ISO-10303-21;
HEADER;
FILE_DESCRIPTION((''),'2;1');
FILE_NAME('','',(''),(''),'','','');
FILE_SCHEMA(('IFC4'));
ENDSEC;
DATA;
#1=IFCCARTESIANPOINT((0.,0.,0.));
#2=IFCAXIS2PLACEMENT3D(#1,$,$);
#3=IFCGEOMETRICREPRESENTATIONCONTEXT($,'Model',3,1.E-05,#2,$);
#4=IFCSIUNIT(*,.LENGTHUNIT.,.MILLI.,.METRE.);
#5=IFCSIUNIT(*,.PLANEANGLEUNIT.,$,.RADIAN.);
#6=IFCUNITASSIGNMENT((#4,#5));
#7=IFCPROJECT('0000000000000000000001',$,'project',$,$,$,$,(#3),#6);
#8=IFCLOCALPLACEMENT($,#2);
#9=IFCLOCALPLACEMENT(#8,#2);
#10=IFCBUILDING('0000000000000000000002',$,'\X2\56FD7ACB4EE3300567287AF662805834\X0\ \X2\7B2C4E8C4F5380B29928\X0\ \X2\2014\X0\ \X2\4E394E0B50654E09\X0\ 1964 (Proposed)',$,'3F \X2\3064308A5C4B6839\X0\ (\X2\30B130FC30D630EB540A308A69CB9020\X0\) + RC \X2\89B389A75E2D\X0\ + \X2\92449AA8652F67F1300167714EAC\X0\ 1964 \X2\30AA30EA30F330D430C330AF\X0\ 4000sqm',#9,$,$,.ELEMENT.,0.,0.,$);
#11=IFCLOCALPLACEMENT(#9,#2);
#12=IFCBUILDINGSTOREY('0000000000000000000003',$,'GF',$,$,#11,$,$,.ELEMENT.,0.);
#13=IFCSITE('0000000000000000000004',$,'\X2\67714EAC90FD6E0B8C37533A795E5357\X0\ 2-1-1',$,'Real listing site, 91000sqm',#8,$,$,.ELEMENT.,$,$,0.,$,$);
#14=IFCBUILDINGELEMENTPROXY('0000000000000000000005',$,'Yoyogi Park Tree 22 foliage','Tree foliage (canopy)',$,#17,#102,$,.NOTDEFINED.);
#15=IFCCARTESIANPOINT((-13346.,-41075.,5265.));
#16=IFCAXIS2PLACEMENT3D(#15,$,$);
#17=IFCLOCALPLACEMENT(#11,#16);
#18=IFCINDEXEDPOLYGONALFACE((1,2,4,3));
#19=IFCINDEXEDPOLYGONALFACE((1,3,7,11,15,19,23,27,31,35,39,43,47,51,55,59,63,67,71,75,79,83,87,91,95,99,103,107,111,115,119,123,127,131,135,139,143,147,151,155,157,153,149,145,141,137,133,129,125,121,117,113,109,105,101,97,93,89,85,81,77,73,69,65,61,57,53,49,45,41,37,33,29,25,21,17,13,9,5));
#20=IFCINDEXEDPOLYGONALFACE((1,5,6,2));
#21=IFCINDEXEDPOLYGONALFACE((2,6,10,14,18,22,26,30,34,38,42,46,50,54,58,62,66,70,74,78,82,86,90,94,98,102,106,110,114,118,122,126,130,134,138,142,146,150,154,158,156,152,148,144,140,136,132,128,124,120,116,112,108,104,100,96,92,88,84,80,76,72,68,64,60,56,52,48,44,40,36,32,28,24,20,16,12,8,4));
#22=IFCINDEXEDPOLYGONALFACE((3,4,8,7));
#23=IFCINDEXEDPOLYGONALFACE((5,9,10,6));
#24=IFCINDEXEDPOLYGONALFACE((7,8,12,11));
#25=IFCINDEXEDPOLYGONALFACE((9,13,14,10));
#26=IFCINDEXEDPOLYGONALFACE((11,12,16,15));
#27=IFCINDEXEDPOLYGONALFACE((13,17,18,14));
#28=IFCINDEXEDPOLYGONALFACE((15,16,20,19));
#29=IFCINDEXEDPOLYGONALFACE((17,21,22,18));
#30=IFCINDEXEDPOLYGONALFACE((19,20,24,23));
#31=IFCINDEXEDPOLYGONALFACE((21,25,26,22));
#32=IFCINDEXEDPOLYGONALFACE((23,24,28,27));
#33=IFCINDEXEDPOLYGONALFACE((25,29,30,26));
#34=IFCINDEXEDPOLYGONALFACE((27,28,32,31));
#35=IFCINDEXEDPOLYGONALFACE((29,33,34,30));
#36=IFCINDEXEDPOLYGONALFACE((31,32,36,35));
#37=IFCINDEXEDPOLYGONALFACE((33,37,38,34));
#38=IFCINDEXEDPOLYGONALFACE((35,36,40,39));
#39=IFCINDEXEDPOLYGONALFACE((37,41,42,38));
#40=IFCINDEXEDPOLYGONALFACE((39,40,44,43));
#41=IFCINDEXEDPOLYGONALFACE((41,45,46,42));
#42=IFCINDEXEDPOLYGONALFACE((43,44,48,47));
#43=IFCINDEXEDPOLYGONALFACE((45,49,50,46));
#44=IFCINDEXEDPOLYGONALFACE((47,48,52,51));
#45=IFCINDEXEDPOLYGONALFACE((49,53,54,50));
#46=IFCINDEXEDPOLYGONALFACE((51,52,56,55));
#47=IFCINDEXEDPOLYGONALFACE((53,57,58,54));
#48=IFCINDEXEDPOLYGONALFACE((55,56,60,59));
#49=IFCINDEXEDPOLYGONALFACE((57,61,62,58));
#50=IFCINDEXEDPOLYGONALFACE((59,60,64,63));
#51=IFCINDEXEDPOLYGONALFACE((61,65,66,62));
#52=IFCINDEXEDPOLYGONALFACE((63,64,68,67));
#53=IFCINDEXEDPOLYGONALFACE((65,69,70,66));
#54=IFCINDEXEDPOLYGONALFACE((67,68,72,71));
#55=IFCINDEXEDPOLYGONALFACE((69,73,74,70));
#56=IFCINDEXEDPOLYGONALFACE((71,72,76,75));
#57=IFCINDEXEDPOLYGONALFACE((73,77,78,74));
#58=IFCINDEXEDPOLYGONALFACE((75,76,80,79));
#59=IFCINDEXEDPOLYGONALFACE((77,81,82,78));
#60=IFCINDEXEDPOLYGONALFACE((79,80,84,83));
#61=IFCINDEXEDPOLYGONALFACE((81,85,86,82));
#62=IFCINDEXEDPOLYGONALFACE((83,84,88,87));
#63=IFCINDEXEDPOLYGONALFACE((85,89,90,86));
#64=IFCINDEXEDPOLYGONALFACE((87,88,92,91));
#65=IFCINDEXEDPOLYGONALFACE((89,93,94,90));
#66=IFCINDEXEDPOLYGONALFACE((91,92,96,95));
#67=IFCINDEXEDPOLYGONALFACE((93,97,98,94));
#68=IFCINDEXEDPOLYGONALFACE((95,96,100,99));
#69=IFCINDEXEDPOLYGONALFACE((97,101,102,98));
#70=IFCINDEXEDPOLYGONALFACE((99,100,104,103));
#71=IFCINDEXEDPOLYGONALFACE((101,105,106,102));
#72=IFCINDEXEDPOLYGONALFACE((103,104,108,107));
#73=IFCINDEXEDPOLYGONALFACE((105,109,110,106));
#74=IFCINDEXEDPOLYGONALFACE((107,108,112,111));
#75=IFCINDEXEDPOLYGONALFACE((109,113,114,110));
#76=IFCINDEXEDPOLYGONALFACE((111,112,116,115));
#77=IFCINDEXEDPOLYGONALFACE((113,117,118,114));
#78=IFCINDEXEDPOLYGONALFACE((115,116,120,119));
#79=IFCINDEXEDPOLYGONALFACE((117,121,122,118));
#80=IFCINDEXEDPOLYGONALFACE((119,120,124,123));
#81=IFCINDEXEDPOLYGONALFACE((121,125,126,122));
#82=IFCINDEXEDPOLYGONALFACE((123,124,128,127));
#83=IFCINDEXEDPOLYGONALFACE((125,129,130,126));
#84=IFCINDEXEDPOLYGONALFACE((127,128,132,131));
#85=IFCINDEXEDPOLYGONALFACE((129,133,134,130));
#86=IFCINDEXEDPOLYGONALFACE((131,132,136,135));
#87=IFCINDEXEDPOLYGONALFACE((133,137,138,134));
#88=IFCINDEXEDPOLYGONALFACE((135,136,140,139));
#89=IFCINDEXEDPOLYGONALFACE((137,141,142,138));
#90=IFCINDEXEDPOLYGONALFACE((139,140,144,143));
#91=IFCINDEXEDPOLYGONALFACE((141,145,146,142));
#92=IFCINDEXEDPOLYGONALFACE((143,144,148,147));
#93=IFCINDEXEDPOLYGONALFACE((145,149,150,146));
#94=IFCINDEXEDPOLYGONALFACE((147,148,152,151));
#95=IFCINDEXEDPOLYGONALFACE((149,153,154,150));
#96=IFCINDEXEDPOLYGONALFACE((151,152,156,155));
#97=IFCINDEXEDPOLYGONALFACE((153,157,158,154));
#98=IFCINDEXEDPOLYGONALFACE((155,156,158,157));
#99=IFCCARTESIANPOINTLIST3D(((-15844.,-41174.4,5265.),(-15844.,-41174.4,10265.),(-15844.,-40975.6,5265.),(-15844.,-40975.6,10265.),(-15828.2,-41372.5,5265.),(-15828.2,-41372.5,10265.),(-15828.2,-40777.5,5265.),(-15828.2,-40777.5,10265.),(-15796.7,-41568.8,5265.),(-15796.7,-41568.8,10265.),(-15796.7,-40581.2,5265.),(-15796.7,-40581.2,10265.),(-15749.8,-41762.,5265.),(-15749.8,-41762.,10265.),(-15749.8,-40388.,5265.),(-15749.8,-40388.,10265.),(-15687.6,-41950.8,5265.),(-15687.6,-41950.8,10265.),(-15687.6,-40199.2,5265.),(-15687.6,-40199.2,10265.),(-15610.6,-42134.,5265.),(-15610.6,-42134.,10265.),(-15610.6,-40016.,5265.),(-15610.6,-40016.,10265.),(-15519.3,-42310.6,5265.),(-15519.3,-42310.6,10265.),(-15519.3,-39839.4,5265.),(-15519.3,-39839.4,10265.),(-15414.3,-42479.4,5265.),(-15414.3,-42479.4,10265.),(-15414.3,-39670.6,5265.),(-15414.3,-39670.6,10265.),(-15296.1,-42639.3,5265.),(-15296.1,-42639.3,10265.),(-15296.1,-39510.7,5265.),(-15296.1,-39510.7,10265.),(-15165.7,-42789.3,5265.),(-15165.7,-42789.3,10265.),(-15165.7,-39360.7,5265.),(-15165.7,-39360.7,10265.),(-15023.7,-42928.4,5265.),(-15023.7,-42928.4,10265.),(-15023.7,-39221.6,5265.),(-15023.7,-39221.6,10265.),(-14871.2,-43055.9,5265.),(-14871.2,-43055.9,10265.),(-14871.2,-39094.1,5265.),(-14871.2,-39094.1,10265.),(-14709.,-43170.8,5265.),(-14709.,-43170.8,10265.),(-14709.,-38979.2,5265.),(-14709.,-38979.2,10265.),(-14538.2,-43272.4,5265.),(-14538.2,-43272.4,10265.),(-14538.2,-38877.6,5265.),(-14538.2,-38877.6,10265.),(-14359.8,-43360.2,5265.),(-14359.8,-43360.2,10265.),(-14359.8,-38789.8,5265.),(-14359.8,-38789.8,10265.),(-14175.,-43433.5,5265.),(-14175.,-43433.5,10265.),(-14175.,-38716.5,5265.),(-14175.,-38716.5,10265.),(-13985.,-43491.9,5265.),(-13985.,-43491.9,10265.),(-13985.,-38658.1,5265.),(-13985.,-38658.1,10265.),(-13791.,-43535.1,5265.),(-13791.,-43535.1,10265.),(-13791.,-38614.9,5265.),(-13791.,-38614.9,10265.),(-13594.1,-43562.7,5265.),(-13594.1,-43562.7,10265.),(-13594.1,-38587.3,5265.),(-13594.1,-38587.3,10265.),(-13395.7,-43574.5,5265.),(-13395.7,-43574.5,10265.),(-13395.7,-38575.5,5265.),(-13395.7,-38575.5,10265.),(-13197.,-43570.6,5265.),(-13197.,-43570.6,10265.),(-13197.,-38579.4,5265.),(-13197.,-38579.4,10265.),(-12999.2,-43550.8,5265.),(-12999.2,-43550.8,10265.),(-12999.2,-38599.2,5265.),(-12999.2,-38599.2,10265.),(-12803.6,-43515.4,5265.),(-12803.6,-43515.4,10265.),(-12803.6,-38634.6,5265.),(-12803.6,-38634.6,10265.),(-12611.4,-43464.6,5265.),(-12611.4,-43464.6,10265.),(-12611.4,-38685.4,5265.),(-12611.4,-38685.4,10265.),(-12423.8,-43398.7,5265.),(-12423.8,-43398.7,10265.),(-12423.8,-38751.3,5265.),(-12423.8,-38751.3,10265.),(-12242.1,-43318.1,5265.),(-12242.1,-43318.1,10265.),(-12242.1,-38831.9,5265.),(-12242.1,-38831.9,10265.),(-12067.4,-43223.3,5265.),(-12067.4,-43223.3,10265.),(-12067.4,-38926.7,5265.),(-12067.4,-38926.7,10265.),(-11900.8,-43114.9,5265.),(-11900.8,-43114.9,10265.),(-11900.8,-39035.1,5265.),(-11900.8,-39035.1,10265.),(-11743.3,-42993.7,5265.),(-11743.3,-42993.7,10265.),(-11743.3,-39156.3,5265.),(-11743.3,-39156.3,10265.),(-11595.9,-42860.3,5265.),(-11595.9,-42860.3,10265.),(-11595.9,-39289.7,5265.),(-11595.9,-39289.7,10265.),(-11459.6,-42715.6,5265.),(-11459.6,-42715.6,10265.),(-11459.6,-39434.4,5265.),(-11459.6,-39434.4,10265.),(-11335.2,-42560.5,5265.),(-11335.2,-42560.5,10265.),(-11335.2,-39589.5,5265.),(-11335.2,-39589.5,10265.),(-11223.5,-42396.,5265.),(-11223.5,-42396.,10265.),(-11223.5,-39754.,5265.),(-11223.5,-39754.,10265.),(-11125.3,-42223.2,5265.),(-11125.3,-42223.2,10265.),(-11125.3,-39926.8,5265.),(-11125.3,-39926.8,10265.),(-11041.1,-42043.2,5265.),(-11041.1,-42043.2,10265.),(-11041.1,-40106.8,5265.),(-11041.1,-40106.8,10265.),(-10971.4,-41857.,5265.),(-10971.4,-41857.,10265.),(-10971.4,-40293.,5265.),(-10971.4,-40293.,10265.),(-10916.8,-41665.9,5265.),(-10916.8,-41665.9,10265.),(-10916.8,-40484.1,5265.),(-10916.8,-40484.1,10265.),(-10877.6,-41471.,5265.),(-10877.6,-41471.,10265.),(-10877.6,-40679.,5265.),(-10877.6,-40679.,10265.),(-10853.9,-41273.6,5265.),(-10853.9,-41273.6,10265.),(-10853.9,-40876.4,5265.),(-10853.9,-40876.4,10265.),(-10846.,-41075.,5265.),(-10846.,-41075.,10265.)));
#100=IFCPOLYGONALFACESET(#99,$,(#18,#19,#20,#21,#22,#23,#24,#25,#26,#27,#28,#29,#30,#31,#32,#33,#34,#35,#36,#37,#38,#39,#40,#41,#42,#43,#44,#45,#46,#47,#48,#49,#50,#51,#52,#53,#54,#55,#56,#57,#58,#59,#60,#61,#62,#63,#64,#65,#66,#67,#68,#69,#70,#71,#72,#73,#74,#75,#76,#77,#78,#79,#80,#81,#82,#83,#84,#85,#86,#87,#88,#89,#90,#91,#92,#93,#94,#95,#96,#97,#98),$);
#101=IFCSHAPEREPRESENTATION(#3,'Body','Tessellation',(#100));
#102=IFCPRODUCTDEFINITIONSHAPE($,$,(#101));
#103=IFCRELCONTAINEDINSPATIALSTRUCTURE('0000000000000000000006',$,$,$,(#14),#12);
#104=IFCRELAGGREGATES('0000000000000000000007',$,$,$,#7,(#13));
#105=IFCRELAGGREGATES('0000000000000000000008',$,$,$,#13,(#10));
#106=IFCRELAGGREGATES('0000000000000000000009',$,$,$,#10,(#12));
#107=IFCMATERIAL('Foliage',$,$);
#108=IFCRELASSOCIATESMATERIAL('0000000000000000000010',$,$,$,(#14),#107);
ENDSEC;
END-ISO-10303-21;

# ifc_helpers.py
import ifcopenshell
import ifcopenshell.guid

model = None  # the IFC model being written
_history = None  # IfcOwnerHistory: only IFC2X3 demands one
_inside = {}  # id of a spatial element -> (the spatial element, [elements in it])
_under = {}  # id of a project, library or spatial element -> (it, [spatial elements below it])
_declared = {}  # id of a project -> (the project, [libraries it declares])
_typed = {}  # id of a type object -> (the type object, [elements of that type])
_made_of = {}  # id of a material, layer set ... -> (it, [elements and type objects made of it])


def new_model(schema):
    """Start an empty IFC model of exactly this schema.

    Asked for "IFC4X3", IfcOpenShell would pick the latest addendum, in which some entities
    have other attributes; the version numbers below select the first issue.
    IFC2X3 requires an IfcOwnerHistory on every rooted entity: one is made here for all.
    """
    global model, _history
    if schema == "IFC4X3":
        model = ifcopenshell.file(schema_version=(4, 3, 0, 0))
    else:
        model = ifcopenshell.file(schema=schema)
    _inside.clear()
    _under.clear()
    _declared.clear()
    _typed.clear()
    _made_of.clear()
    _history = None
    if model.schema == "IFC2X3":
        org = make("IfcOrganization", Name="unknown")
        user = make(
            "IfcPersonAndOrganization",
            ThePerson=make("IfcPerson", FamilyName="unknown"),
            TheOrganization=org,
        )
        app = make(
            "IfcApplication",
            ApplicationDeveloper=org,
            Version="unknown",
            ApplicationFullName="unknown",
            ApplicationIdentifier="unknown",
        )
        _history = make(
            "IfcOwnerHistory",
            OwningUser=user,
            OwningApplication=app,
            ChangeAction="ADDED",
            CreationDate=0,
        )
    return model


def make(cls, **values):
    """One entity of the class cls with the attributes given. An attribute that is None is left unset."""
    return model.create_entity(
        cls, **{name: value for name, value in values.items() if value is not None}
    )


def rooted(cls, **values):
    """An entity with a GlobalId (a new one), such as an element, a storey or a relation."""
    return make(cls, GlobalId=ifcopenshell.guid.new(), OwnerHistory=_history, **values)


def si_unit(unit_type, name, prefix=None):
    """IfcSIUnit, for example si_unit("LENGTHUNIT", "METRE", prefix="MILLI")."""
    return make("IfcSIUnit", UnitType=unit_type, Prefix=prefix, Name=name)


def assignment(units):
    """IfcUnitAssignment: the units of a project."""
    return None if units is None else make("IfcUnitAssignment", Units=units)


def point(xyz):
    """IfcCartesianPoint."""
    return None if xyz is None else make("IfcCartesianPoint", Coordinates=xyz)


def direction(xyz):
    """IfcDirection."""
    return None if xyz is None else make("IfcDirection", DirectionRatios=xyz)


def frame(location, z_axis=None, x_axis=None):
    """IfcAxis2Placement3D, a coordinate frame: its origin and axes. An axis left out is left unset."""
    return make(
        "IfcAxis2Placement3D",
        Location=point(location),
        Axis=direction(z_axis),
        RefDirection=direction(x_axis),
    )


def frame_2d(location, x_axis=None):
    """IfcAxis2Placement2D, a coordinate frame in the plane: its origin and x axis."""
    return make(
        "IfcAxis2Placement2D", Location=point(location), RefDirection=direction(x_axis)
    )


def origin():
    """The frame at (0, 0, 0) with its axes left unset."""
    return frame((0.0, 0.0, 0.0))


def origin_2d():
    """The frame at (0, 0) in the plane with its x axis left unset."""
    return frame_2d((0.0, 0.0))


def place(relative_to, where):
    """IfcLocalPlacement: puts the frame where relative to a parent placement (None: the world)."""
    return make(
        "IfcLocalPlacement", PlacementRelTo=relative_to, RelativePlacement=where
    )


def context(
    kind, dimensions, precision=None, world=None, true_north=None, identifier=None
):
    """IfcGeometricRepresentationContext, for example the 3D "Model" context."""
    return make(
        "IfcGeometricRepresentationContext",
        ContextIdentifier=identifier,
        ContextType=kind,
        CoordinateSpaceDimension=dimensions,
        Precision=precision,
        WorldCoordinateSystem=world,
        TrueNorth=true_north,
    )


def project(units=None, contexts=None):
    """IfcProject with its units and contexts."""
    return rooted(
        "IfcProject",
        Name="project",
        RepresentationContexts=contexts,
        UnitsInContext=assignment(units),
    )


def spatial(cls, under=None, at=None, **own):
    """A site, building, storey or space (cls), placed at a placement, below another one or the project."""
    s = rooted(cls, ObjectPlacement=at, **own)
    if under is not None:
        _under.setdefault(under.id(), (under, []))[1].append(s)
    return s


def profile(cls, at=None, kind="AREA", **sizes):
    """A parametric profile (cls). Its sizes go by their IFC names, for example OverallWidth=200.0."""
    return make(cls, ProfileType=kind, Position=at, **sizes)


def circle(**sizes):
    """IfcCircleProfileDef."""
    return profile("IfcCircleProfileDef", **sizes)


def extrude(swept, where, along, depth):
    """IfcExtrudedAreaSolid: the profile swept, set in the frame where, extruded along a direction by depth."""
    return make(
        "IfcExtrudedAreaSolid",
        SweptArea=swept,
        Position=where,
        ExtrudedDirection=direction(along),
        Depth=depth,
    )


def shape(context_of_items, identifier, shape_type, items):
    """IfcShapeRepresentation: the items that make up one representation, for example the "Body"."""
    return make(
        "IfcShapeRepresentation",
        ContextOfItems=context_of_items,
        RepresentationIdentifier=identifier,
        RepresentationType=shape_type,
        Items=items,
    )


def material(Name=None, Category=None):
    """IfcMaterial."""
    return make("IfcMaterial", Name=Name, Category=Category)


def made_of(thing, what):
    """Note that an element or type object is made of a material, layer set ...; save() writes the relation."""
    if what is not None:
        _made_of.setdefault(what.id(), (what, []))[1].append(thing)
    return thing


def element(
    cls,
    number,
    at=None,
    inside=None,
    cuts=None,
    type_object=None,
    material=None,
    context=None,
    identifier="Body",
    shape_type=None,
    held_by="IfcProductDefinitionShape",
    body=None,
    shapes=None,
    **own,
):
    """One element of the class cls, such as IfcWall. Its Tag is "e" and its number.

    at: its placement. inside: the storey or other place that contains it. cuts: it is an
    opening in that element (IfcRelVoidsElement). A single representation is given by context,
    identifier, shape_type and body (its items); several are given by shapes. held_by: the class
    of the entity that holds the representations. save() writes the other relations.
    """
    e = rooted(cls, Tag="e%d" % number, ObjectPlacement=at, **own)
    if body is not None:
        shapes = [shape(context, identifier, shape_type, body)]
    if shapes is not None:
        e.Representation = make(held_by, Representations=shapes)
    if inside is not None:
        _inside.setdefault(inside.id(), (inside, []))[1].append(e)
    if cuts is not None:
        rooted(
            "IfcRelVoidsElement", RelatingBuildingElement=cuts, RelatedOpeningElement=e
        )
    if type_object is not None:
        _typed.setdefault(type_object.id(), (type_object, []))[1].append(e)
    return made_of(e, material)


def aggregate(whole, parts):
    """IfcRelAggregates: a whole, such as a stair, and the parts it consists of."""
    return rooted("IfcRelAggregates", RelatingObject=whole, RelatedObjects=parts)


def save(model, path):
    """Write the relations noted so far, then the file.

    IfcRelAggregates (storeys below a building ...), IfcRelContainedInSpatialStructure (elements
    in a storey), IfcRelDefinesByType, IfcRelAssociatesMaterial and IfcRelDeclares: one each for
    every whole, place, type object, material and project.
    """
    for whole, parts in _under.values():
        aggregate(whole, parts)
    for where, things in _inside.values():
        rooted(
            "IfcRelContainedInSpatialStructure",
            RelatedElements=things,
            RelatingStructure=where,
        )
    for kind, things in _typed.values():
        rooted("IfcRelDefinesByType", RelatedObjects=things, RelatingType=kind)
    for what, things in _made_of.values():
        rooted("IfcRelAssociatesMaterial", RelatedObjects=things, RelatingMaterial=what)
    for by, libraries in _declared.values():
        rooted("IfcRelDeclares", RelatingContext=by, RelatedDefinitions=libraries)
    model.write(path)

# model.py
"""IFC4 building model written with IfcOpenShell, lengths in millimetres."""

from ifc_helpers import new_model, si_unit, frame, origin, origin_2d, place, context, project, spatial, circle, extrude, material, element, save


model = new_model("IFC4")

# Units and contexts
model_context = context("Model", 3, precision=1e-05, world=origin())
ifc_project = project(units=[si_unit("LENGTHUNIT", "METRE", prefix="MILLI"), si_unit("PLANEANGLEUNIT", "RADIAN")], contexts=[model_context])

# Site, building, storey
site_placement = place(None, origin())
site = spatial("IfcSite", under=ifc_project, at=site_placement, Name="東京都渋谷区神南 2-1-1", ObjectType="Real listing site, 91000sqm", CompositionType="ELEMENT", RefElevation=0.0)
building_placement = place(site_placement, origin())
building = spatial("IfcBuilding", under=site, at=building_placement, Name="国立代々木競技場 第二体育館 — 丹下健三 1964 (Proposed)", ObjectType="3F つり屋根 (ケーブル吊り構造) + RC 観覧席 + 鉄骨支柱、東京 1964 オリンピック 4000sqm", CompositionType="ELEMENT", ElevationOfRefHeight=0.0, ElevationOfTerrain=0.0)
storey_placement = place(building_placement, origin())
storey = spatial("IfcBuildingStorey", under=building, at=storey_placement, Name="GF", CompositionType="ELEMENT", Elevation=0.0)

# Building element proxy
ifc_material_1 = material(Name="Foliage")
proxy_1_placement = place(storey_placement, frame((-13346.0, -41075.0, 5265.0)))
element("IfcBuildingElementProxy", 1, at=proxy_1_placement, inside=storey, material=ifc_material_1, Name="Yoyogi Park Tree 22 foliage", Description="Tree foliage (canopy)", PredefinedType="NOTDEFINED", context=model_context, shape_type="SweptSolid", body=[
    extrude(circle(Radius=2500.0, at=origin_2d()), frame((-13346.0, -41075.0, 5265.0)), (0.0, 0.0, 1.0), 5000.0),
])

save(model, "model.ifc")
